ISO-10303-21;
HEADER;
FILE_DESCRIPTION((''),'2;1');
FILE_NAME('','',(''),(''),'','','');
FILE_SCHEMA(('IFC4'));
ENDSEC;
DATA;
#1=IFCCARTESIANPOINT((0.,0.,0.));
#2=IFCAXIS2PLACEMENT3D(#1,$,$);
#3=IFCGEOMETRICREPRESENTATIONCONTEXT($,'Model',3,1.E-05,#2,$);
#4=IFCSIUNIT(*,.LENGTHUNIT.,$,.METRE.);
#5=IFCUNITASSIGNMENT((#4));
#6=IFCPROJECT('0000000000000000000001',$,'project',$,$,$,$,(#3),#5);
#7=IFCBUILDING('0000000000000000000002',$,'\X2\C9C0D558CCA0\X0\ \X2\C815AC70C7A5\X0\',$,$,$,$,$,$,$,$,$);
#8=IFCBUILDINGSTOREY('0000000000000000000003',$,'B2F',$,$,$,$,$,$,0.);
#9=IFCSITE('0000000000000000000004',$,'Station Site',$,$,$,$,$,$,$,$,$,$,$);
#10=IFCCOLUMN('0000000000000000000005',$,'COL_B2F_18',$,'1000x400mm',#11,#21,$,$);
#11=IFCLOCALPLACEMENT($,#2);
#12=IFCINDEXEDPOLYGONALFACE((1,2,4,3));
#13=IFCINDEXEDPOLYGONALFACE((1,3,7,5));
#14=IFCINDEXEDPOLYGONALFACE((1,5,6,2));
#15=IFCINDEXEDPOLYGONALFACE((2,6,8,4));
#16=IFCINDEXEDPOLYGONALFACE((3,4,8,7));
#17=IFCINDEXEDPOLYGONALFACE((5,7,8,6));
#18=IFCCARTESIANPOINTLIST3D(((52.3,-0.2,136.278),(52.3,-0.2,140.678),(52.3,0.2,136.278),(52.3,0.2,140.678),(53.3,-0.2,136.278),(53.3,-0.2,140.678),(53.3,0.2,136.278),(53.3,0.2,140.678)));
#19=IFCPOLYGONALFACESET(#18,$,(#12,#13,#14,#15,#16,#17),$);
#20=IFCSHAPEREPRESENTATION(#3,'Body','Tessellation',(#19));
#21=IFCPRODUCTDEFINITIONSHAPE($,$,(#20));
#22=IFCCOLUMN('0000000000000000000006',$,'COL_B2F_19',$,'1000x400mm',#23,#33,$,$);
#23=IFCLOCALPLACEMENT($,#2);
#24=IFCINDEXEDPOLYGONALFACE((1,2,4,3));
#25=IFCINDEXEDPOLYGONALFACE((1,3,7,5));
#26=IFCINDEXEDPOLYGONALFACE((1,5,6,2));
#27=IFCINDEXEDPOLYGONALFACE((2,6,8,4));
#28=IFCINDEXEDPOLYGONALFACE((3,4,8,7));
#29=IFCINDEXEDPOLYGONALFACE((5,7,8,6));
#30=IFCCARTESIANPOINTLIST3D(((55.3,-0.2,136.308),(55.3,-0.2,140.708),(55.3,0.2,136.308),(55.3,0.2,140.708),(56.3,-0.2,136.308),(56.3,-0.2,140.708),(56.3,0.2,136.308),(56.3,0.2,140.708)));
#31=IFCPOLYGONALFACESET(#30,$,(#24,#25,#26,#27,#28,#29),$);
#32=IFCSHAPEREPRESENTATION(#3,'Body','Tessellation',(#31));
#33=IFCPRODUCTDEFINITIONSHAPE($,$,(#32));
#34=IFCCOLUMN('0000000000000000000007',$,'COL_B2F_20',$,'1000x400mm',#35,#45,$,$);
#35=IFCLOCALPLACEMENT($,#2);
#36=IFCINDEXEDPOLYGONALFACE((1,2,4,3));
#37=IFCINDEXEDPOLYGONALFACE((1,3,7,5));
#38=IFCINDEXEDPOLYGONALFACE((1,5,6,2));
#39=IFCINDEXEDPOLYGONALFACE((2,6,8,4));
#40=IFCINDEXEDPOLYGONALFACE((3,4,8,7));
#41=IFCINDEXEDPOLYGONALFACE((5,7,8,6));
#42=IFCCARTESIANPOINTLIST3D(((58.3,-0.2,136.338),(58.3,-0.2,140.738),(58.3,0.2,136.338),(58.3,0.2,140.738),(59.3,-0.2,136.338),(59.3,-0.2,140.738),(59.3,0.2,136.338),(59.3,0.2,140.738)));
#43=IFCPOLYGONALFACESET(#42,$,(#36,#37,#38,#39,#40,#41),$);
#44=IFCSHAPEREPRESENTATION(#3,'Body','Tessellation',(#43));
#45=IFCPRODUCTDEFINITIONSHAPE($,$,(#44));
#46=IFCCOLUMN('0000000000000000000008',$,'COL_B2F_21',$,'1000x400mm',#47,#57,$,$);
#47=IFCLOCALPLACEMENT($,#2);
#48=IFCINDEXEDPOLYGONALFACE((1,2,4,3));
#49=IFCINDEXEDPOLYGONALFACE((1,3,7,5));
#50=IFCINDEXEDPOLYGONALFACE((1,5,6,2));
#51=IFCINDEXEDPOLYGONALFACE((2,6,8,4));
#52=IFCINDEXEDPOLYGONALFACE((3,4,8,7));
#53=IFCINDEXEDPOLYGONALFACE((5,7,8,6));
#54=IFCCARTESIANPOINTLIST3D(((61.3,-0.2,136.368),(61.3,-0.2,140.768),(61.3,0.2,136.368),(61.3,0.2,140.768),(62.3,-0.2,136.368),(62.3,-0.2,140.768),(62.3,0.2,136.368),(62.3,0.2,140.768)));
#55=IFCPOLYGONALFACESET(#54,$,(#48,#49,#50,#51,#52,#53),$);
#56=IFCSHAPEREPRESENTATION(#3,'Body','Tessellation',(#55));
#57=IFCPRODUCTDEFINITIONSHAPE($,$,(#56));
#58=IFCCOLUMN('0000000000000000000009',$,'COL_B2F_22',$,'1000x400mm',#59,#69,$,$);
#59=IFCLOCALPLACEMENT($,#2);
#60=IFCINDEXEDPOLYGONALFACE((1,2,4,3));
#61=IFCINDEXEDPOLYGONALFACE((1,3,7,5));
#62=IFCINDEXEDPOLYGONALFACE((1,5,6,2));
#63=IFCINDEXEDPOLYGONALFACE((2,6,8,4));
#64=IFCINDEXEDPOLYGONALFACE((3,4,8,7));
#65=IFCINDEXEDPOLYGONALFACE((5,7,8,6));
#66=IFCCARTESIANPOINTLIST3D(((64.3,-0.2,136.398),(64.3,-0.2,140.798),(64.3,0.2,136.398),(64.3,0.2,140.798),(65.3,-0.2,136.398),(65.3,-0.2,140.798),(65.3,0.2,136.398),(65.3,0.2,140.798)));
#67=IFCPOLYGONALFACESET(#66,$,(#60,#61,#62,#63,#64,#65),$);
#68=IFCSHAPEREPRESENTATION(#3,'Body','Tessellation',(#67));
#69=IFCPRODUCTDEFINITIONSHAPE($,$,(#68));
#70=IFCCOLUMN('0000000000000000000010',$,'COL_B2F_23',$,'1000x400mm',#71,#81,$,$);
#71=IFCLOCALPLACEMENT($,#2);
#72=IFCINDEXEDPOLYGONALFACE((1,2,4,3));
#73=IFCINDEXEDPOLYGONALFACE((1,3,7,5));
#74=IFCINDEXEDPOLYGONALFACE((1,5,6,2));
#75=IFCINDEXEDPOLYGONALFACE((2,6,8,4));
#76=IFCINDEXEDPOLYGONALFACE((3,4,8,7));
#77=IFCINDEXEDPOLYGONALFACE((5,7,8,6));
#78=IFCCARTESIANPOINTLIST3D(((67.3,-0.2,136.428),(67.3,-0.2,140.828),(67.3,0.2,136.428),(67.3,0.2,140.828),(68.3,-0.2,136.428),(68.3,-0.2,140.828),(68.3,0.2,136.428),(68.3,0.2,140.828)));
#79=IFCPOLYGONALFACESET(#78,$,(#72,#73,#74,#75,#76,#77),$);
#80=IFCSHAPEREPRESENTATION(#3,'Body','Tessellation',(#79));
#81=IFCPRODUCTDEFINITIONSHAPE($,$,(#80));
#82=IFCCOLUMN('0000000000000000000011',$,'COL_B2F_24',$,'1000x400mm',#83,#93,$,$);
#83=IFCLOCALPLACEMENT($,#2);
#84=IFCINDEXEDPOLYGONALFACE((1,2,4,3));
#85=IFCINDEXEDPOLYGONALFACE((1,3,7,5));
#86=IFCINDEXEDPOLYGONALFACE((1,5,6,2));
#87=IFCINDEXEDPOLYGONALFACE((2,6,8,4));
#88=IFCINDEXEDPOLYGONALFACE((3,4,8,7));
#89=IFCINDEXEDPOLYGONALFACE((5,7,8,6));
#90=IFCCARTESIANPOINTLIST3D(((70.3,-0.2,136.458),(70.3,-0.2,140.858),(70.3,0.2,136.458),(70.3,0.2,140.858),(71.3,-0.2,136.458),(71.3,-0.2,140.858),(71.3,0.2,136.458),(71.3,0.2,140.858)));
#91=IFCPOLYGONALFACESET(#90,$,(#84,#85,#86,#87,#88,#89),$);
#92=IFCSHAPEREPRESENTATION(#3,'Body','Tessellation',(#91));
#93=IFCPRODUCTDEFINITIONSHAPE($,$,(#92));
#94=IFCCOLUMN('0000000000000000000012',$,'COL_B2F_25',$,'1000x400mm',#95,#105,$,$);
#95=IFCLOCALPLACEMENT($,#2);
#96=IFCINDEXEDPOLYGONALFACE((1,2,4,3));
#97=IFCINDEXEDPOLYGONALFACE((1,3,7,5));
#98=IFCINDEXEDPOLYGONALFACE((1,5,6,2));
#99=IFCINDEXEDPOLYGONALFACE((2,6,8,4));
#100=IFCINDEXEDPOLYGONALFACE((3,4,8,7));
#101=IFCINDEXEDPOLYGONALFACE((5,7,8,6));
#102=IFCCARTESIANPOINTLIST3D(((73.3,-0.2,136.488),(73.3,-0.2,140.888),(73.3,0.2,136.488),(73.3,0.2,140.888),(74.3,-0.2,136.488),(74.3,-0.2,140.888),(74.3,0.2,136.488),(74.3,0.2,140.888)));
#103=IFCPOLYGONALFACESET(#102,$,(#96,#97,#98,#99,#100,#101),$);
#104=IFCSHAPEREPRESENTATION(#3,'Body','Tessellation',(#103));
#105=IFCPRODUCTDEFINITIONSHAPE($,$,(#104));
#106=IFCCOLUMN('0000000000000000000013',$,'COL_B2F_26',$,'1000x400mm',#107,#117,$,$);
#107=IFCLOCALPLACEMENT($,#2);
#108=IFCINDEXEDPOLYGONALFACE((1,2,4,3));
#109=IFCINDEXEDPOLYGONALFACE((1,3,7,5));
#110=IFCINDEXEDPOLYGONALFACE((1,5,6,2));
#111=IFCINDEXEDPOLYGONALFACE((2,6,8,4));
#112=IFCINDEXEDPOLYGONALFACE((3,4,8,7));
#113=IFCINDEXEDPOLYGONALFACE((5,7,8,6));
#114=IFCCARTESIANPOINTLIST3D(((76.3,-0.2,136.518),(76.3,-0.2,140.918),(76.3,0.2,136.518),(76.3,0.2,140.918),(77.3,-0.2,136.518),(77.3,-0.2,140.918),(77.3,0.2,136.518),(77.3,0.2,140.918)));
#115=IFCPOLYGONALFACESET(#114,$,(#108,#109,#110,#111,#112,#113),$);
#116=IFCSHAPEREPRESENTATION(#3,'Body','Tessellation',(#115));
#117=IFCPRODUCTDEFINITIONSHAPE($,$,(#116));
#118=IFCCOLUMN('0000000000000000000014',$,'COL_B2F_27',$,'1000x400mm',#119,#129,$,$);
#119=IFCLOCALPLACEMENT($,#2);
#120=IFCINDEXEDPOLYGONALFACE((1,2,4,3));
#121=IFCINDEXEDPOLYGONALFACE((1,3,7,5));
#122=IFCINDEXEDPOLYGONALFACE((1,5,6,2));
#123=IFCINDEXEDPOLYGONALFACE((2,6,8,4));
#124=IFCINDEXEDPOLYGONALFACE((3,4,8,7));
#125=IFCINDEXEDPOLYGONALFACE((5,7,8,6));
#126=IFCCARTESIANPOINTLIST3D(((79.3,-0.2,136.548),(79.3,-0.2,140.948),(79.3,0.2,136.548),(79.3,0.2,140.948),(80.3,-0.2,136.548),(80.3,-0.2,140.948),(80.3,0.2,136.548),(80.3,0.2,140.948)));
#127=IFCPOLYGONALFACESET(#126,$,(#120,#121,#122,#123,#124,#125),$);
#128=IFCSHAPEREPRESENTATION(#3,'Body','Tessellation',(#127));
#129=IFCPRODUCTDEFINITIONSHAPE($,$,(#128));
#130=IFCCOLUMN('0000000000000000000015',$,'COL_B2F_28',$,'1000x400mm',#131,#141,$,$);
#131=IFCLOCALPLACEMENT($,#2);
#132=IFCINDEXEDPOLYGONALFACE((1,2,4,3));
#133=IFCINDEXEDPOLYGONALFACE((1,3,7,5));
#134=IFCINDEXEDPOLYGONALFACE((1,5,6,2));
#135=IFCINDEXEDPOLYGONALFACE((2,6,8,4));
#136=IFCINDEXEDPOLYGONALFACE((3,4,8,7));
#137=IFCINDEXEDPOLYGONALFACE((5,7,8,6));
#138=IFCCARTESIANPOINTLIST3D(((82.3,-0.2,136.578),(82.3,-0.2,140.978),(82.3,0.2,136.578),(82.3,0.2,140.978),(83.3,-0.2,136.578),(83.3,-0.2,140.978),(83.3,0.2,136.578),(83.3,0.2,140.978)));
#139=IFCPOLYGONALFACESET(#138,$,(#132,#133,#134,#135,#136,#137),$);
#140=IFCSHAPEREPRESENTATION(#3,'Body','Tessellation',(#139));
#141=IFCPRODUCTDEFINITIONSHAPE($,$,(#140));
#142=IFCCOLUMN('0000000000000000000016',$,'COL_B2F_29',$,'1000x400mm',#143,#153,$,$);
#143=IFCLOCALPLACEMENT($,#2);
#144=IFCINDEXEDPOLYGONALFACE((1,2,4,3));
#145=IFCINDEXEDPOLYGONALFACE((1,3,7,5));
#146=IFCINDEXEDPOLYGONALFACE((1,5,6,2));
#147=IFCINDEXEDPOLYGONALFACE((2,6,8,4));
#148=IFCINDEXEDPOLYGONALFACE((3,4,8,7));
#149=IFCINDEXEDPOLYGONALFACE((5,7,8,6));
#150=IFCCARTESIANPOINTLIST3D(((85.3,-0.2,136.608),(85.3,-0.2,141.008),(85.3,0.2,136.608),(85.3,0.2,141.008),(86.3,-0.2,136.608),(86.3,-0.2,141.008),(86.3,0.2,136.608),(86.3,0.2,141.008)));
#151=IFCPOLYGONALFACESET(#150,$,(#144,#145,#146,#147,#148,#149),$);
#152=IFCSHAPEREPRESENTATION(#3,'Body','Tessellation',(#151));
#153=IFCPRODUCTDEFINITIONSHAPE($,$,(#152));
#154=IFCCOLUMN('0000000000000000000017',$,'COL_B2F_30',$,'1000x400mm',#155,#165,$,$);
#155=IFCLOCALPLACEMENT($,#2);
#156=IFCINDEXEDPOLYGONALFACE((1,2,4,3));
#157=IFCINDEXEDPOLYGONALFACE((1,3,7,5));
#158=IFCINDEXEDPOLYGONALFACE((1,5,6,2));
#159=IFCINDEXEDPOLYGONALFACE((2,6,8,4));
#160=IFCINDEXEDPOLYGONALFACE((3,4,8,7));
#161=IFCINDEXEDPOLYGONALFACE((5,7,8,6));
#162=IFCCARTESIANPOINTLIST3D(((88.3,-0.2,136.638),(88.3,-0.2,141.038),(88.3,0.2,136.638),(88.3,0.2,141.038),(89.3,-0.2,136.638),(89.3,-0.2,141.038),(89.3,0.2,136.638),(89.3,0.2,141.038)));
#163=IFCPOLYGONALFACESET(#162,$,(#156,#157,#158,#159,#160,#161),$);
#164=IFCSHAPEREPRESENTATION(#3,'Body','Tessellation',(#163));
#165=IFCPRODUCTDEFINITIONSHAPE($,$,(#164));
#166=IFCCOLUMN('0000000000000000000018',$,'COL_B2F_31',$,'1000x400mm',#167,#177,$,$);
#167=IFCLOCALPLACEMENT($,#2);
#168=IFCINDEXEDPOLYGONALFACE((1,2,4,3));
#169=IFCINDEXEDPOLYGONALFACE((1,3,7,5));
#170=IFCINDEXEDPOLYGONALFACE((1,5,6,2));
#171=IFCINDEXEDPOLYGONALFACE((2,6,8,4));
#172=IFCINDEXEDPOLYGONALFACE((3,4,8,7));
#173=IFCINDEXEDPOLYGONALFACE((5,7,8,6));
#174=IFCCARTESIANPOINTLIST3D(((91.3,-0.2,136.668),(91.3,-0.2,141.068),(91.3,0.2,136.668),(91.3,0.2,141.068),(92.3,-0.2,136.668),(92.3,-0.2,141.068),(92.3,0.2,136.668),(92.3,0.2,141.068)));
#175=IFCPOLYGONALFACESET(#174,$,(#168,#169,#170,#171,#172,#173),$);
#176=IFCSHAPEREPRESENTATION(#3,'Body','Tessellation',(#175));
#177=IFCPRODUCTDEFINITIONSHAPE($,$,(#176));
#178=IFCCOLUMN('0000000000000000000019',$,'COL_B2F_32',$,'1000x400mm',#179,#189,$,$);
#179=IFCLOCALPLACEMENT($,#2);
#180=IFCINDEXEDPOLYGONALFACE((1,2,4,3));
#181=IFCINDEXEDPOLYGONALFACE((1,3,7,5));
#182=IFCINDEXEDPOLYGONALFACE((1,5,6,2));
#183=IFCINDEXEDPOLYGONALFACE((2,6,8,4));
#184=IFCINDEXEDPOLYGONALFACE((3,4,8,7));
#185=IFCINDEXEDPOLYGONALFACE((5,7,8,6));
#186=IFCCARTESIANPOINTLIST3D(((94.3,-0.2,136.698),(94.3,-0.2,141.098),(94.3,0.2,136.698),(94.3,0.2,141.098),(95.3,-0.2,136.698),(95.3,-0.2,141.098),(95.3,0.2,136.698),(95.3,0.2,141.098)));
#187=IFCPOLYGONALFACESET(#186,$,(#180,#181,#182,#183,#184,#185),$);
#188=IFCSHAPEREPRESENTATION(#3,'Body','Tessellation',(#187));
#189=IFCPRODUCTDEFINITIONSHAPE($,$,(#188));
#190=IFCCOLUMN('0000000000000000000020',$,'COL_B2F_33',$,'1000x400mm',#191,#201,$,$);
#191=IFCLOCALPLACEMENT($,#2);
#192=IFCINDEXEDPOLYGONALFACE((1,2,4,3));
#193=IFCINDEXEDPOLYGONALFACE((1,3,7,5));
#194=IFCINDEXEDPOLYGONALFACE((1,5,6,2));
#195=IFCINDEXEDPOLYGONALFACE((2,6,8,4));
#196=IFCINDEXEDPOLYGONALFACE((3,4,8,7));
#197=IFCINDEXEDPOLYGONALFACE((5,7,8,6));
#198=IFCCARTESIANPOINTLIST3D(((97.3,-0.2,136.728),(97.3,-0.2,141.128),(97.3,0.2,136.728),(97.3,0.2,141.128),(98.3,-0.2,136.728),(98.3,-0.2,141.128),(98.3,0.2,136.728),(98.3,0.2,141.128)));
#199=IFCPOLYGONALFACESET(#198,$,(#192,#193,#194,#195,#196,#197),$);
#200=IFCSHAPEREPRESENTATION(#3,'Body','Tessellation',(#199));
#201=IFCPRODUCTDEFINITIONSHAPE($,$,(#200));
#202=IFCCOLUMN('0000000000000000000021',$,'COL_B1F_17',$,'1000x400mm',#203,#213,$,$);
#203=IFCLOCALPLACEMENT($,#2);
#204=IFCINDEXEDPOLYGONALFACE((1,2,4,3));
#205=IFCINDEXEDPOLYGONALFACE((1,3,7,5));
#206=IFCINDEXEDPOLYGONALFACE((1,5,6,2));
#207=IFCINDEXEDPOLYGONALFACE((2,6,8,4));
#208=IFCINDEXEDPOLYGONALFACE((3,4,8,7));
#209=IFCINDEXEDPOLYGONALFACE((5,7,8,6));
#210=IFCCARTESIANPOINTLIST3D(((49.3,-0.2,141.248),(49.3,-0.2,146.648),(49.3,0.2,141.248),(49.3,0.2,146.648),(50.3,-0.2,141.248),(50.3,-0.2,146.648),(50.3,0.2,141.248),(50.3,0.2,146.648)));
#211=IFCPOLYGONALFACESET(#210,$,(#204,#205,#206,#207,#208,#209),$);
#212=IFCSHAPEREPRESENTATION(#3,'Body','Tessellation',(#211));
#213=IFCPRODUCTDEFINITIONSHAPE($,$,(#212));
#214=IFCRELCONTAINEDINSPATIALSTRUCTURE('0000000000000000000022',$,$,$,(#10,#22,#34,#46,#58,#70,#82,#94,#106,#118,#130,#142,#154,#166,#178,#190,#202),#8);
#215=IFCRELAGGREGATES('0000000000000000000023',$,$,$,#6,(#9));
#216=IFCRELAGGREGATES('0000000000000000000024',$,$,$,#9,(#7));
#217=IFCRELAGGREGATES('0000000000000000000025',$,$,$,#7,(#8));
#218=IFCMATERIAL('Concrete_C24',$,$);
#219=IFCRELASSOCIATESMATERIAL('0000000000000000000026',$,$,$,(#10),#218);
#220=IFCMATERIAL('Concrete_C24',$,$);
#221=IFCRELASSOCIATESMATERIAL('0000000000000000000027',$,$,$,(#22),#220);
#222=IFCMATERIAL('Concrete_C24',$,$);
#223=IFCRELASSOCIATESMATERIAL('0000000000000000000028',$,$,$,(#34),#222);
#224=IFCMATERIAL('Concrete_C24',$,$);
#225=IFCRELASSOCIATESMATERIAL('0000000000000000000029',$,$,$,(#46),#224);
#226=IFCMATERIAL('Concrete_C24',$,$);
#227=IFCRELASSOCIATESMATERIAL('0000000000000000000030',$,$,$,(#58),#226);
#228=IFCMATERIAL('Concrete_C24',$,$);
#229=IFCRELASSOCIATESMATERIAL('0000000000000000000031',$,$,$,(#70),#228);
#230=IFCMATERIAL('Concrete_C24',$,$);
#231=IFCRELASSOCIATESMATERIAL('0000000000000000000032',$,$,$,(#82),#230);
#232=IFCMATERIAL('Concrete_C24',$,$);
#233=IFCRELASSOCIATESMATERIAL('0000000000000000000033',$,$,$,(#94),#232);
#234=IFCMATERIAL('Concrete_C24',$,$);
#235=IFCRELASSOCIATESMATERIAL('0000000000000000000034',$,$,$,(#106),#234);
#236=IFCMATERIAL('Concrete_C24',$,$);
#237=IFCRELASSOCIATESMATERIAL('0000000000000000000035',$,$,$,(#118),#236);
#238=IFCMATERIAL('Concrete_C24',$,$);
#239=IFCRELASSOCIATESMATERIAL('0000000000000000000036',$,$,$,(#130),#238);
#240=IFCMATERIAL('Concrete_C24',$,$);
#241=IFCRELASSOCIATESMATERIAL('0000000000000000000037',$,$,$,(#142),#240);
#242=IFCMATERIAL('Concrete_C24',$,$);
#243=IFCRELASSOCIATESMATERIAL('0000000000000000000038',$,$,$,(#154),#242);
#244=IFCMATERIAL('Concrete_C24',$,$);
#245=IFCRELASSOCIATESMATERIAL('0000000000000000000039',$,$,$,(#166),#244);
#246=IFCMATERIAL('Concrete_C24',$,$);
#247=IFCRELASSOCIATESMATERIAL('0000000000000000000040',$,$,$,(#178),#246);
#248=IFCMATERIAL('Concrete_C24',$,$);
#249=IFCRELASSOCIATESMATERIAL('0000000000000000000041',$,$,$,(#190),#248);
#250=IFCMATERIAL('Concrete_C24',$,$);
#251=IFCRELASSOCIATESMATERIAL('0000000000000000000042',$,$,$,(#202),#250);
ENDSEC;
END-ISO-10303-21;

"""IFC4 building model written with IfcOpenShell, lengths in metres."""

from ifc_helpers import new_model, si_unit, frame, origin, place, context, project, spatial, rectangle, extrude, material, element, save


model = new_model("IFC4")

# Units and contexts
model_context = context("Model", 3, precision=1e-05, world=origin())
ifc_project = project(units=[si_unit("LENGTHUNIT", "METRE")], contexts=[model_context])

# Site, building, storey
site = spatial("IfcSite", under=ifc_project, Name="Station Site")
building = spatial("IfcBuilding", under=site, Name="지하철 정거장")
storey = spatial("IfcBuildingStorey", under=building, Name="B2F", Elevation=0.0)

# Columns
ifc_material_1 = material(Name="Concrete_C24")
column_1_placement = place(None, frame((52.8, 0.0, 136.278)))
element("IfcColumn", 1, at=column_1_placement, inside=storey, material=ifc_material_1, Name="COL_B2F_18", ObjectType="1000x400mm", context=model_context, shape_type="SweptSolid", body=[
    extrude(rectangle(XDim=1.0, YDim=0.4), origin(), (0.0, 0.0, 1.0), 4.4),
])
ifc_material_2 = material(Name="Concrete_C24")
column_2_placement = place(None, frame((55.8, 0.0, 136.308)))
element("IfcColumn", 2, at=column_2_placement, inside=storey, material=ifc_material_2, Name="COL_B2F_19", ObjectType="1000x400mm", context=model_context, shape_type="SweptSolid", body=[
    extrude(rectangle(XDim=1.0, YDim=0.4), origin(), (0.0, 0.0, 1.0), 4.4),
])
ifc_material_3 = material(Name="Concrete_C24")
column_3_placement = place(None, frame((58.8, 0.0, 136.338)))
element("IfcColumn", 3, at=column_3_placement, inside=storey, material=ifc_material_3, Name="COL_B2F_20", ObjectType="1000x400mm", context=model_context, shape_type="SweptSolid", body=[
    extrude(rectangle(XDim=1.0, YDim=0.4), origin(), (0.0, 0.0, 1.0), 4.4),
])
ifc_material_4 = material(Name="Concrete_C24")
column_4_placement = place(None, frame((61.8, 0.0, 136.368)))
element("IfcColumn", 4, at=column_4_placement, inside=storey, material=ifc_material_4, Name="COL_B2F_21", ObjectType="1000x400mm", context=model_context, shape_type="SweptSolid", body=[
    extrude(rectangle(XDim=1.0, YDim=0.4), origin(), (0.0, 0.0, 1.0), 4.4),
])
ifc_material_5 = material(Name="Concrete_C24")
column_5_placement = place(None, frame((64.8, 0.0, 136.398)))
element("IfcColumn", 5, at=column_5_placement, inside=storey, material=ifc_material_5, Name="COL_B2F_22", ObjectType="1000x400mm", context=model_context, shape_type="SweptSolid", body=[
    extrude(rectangle(XDim=1.0, YDim=0.4), origin(), (0.0, 0.0, 1.0), 4.4),
])
ifc_material_6 = material(Name="Concrete_C24")
column_6_placement = place(None, frame((67.8, 0.0, 136.428)))
element("IfcColumn", 6, at=column_6_placement, inside=storey, material=ifc_material_6, Name="COL_B2F_23", ObjectType="1000x400mm", context=model_context, shape_type="SweptSolid", body=[
    extrude(rectangle(XDim=1.0, YDim=0.4), origin(), (0.0, 0.0, 1.0), 4.4),
])
ifc_material_7 = material(Name="Concrete_C24")
column_7_placement = place(None, frame((70.8, 0.0, 136.458)))
element("IfcColumn", 7, at=column_7_placement, inside=storey, material=ifc_material_7, Name="COL_B2F_24", ObjectType="1000x400mm", context=model_context, shape_type="SweptSolid", body=[
    extrude(rectangle(XDim=1.0, YDim=0.4), origin(), (0.0, 0.0, 1.0), 4.4),
])
ifc_material_8 = material(Name="Concrete_C24")
column_8_placement = place(None, frame((73.8, 0.0, 136.488)))
element("IfcColumn", 8, at=column_8_placement, inside=storey, material=ifc_material_8, Name="COL_B2F_25", ObjectType="1000x400mm", context=model_context, shape_type="SweptSolid", body=[
    extrude(rectangle(XDim=1.0, YDim=0.4), origin(), (0.0, 0.0, 1.0), 4.4),
])
ifc_material_9 = material(Name="Concrete_C24")
column_9_placement = place(None, frame((76.8, 0.0, 136.518)))
element("IfcColumn", 9, at=column_9_placement, inside=storey, material=ifc_material_9, Name="COL_B2F_26", ObjectType="1000x400mm", context=model_context, shape_type="SweptSolid", body=[
    extrude(rectangle(XDim=1.0, YDim=0.4), origin(), (0.0, 0.0, 1.0), 4.4),
])
ifc_material_10 = material(Name="Concrete_C24")
column_10_placement = place(None, frame((79.8, 0.0, 136.548)))
element("IfcColumn", 10, at=column_10_placement, inside=storey, material=ifc_material_10, Name="COL_B2F_27", ObjectType="1000x400mm", context=model_context, shape_type="SweptSolid", body=[
    extrude(rectangle(XDim=1.0, YDim=0.4), origin(), (0.0, 0.0, 1.0), 4.4),
])
ifc_material_11 = material(Name="Concrete_C24")
column_11_placement = place(None, frame((82.8, 0.0, 136.578)))
element("IfcColumn", 11, at=column_11_placement, inside=storey, material=ifc_material_11, Name="COL_B2F_28", ObjectType="1000x400mm", context=model_context, shape_type="SweptSolid", body=[
    extrude(rectangle(XDim=1.0, YDim=0.4), origin(), (0.0, 0.0, 1.0), 4.4),
])
ifc_material_12 = material(Name="Concrete_C24")
column_12_placement = place(None, frame((85.8, 0.0, 136.608)))
element("IfcColumn", 12, at=column_12_placement, inside=storey, material=ifc_material_12, Name="COL_B2F_29", ObjectType="1000x400mm", context=model_context, shape_type="SweptSolid", body=[
    extrude(rectangle(XDim=1.0, YDim=0.4), origin(), (0.0, 0.0, 1.0), 4.4),
])
ifc_material_13 = material(Name="Concrete_C24")
column_13_placement = place(None, frame((88.8, 0.0, 136.638)))
element("IfcColumn", 13, at=column_13_placement, inside=storey, material=ifc_material_13, Name="COL_B2F_30", ObjectType="1000x400mm", context=model_context, shape_type="SweptSolid", body=[
    extrude(rectangle(XDim=1.0, YDim=0.4), origin(), (0.0, 0.0, 1.0), 4.4),
])
ifc_material_14 = material(Name="Concrete_C24")
column_14_placement = place(None, frame((91.8, 0.0, 136.668)))
element("IfcColumn", 14, at=column_14_placement, inside=storey, material=ifc_material_14, Name="COL_B2F_31", ObjectType="1000x400mm", context=model_context, shape_type="SweptSolid", body=[
    extrude(rectangle(XDim=1.0, YDim=0.4), origin(), (0.0, 0.0, 1.0), 4.4),
])
ifc_material_15 = material(Name="Concrete_C24")
column_15_placement = place(None, frame((94.8, 0.0, 136.698)))
element("IfcColumn", 15, at=column_15_placement, inside=storey, material=ifc_material_15, Name="COL_B2F_32", ObjectType="1000x400mm", context=model_context, shape_type="SweptSolid", body=[
    extrude(rectangle(XDim=1.0, YDim=0.4), origin(), (0.0, 0.0, 1.0), 4.4),
])
ifc_material_16 = material(Name="Concrete_C24")
column_16_placement = place(None, frame((97.8, 0.0, 136.728)))
element("IfcColumn", 16, at=column_16_placement, inside=storey, material=ifc_material_16, Name="COL_B2F_33", ObjectType="1000x400mm", context=model_context, shape_type="SweptSolid", body=[
    extrude(rectangle(XDim=1.0, YDim=0.4), origin(), (0.0, 0.0, 1.0), 4.4),
])
ifc_material_17 = material(Name="Concrete_C24")
column_17_placement = place(None, frame((49.8, 0.0, 141.248)))
element("IfcColumn", 17, at=column_17_placement, inside=storey, material=ifc_material_17, Name="COL_B1F_17", ObjectType="1000x400mm", context=model_context, shape_type="SweptSolid", body=[
    extrude(rectangle(XDim=1.0, YDim=0.4), origin(), (0.0, 0.0, 1.0), 5.4),
])

save(model, "model.ifc")
